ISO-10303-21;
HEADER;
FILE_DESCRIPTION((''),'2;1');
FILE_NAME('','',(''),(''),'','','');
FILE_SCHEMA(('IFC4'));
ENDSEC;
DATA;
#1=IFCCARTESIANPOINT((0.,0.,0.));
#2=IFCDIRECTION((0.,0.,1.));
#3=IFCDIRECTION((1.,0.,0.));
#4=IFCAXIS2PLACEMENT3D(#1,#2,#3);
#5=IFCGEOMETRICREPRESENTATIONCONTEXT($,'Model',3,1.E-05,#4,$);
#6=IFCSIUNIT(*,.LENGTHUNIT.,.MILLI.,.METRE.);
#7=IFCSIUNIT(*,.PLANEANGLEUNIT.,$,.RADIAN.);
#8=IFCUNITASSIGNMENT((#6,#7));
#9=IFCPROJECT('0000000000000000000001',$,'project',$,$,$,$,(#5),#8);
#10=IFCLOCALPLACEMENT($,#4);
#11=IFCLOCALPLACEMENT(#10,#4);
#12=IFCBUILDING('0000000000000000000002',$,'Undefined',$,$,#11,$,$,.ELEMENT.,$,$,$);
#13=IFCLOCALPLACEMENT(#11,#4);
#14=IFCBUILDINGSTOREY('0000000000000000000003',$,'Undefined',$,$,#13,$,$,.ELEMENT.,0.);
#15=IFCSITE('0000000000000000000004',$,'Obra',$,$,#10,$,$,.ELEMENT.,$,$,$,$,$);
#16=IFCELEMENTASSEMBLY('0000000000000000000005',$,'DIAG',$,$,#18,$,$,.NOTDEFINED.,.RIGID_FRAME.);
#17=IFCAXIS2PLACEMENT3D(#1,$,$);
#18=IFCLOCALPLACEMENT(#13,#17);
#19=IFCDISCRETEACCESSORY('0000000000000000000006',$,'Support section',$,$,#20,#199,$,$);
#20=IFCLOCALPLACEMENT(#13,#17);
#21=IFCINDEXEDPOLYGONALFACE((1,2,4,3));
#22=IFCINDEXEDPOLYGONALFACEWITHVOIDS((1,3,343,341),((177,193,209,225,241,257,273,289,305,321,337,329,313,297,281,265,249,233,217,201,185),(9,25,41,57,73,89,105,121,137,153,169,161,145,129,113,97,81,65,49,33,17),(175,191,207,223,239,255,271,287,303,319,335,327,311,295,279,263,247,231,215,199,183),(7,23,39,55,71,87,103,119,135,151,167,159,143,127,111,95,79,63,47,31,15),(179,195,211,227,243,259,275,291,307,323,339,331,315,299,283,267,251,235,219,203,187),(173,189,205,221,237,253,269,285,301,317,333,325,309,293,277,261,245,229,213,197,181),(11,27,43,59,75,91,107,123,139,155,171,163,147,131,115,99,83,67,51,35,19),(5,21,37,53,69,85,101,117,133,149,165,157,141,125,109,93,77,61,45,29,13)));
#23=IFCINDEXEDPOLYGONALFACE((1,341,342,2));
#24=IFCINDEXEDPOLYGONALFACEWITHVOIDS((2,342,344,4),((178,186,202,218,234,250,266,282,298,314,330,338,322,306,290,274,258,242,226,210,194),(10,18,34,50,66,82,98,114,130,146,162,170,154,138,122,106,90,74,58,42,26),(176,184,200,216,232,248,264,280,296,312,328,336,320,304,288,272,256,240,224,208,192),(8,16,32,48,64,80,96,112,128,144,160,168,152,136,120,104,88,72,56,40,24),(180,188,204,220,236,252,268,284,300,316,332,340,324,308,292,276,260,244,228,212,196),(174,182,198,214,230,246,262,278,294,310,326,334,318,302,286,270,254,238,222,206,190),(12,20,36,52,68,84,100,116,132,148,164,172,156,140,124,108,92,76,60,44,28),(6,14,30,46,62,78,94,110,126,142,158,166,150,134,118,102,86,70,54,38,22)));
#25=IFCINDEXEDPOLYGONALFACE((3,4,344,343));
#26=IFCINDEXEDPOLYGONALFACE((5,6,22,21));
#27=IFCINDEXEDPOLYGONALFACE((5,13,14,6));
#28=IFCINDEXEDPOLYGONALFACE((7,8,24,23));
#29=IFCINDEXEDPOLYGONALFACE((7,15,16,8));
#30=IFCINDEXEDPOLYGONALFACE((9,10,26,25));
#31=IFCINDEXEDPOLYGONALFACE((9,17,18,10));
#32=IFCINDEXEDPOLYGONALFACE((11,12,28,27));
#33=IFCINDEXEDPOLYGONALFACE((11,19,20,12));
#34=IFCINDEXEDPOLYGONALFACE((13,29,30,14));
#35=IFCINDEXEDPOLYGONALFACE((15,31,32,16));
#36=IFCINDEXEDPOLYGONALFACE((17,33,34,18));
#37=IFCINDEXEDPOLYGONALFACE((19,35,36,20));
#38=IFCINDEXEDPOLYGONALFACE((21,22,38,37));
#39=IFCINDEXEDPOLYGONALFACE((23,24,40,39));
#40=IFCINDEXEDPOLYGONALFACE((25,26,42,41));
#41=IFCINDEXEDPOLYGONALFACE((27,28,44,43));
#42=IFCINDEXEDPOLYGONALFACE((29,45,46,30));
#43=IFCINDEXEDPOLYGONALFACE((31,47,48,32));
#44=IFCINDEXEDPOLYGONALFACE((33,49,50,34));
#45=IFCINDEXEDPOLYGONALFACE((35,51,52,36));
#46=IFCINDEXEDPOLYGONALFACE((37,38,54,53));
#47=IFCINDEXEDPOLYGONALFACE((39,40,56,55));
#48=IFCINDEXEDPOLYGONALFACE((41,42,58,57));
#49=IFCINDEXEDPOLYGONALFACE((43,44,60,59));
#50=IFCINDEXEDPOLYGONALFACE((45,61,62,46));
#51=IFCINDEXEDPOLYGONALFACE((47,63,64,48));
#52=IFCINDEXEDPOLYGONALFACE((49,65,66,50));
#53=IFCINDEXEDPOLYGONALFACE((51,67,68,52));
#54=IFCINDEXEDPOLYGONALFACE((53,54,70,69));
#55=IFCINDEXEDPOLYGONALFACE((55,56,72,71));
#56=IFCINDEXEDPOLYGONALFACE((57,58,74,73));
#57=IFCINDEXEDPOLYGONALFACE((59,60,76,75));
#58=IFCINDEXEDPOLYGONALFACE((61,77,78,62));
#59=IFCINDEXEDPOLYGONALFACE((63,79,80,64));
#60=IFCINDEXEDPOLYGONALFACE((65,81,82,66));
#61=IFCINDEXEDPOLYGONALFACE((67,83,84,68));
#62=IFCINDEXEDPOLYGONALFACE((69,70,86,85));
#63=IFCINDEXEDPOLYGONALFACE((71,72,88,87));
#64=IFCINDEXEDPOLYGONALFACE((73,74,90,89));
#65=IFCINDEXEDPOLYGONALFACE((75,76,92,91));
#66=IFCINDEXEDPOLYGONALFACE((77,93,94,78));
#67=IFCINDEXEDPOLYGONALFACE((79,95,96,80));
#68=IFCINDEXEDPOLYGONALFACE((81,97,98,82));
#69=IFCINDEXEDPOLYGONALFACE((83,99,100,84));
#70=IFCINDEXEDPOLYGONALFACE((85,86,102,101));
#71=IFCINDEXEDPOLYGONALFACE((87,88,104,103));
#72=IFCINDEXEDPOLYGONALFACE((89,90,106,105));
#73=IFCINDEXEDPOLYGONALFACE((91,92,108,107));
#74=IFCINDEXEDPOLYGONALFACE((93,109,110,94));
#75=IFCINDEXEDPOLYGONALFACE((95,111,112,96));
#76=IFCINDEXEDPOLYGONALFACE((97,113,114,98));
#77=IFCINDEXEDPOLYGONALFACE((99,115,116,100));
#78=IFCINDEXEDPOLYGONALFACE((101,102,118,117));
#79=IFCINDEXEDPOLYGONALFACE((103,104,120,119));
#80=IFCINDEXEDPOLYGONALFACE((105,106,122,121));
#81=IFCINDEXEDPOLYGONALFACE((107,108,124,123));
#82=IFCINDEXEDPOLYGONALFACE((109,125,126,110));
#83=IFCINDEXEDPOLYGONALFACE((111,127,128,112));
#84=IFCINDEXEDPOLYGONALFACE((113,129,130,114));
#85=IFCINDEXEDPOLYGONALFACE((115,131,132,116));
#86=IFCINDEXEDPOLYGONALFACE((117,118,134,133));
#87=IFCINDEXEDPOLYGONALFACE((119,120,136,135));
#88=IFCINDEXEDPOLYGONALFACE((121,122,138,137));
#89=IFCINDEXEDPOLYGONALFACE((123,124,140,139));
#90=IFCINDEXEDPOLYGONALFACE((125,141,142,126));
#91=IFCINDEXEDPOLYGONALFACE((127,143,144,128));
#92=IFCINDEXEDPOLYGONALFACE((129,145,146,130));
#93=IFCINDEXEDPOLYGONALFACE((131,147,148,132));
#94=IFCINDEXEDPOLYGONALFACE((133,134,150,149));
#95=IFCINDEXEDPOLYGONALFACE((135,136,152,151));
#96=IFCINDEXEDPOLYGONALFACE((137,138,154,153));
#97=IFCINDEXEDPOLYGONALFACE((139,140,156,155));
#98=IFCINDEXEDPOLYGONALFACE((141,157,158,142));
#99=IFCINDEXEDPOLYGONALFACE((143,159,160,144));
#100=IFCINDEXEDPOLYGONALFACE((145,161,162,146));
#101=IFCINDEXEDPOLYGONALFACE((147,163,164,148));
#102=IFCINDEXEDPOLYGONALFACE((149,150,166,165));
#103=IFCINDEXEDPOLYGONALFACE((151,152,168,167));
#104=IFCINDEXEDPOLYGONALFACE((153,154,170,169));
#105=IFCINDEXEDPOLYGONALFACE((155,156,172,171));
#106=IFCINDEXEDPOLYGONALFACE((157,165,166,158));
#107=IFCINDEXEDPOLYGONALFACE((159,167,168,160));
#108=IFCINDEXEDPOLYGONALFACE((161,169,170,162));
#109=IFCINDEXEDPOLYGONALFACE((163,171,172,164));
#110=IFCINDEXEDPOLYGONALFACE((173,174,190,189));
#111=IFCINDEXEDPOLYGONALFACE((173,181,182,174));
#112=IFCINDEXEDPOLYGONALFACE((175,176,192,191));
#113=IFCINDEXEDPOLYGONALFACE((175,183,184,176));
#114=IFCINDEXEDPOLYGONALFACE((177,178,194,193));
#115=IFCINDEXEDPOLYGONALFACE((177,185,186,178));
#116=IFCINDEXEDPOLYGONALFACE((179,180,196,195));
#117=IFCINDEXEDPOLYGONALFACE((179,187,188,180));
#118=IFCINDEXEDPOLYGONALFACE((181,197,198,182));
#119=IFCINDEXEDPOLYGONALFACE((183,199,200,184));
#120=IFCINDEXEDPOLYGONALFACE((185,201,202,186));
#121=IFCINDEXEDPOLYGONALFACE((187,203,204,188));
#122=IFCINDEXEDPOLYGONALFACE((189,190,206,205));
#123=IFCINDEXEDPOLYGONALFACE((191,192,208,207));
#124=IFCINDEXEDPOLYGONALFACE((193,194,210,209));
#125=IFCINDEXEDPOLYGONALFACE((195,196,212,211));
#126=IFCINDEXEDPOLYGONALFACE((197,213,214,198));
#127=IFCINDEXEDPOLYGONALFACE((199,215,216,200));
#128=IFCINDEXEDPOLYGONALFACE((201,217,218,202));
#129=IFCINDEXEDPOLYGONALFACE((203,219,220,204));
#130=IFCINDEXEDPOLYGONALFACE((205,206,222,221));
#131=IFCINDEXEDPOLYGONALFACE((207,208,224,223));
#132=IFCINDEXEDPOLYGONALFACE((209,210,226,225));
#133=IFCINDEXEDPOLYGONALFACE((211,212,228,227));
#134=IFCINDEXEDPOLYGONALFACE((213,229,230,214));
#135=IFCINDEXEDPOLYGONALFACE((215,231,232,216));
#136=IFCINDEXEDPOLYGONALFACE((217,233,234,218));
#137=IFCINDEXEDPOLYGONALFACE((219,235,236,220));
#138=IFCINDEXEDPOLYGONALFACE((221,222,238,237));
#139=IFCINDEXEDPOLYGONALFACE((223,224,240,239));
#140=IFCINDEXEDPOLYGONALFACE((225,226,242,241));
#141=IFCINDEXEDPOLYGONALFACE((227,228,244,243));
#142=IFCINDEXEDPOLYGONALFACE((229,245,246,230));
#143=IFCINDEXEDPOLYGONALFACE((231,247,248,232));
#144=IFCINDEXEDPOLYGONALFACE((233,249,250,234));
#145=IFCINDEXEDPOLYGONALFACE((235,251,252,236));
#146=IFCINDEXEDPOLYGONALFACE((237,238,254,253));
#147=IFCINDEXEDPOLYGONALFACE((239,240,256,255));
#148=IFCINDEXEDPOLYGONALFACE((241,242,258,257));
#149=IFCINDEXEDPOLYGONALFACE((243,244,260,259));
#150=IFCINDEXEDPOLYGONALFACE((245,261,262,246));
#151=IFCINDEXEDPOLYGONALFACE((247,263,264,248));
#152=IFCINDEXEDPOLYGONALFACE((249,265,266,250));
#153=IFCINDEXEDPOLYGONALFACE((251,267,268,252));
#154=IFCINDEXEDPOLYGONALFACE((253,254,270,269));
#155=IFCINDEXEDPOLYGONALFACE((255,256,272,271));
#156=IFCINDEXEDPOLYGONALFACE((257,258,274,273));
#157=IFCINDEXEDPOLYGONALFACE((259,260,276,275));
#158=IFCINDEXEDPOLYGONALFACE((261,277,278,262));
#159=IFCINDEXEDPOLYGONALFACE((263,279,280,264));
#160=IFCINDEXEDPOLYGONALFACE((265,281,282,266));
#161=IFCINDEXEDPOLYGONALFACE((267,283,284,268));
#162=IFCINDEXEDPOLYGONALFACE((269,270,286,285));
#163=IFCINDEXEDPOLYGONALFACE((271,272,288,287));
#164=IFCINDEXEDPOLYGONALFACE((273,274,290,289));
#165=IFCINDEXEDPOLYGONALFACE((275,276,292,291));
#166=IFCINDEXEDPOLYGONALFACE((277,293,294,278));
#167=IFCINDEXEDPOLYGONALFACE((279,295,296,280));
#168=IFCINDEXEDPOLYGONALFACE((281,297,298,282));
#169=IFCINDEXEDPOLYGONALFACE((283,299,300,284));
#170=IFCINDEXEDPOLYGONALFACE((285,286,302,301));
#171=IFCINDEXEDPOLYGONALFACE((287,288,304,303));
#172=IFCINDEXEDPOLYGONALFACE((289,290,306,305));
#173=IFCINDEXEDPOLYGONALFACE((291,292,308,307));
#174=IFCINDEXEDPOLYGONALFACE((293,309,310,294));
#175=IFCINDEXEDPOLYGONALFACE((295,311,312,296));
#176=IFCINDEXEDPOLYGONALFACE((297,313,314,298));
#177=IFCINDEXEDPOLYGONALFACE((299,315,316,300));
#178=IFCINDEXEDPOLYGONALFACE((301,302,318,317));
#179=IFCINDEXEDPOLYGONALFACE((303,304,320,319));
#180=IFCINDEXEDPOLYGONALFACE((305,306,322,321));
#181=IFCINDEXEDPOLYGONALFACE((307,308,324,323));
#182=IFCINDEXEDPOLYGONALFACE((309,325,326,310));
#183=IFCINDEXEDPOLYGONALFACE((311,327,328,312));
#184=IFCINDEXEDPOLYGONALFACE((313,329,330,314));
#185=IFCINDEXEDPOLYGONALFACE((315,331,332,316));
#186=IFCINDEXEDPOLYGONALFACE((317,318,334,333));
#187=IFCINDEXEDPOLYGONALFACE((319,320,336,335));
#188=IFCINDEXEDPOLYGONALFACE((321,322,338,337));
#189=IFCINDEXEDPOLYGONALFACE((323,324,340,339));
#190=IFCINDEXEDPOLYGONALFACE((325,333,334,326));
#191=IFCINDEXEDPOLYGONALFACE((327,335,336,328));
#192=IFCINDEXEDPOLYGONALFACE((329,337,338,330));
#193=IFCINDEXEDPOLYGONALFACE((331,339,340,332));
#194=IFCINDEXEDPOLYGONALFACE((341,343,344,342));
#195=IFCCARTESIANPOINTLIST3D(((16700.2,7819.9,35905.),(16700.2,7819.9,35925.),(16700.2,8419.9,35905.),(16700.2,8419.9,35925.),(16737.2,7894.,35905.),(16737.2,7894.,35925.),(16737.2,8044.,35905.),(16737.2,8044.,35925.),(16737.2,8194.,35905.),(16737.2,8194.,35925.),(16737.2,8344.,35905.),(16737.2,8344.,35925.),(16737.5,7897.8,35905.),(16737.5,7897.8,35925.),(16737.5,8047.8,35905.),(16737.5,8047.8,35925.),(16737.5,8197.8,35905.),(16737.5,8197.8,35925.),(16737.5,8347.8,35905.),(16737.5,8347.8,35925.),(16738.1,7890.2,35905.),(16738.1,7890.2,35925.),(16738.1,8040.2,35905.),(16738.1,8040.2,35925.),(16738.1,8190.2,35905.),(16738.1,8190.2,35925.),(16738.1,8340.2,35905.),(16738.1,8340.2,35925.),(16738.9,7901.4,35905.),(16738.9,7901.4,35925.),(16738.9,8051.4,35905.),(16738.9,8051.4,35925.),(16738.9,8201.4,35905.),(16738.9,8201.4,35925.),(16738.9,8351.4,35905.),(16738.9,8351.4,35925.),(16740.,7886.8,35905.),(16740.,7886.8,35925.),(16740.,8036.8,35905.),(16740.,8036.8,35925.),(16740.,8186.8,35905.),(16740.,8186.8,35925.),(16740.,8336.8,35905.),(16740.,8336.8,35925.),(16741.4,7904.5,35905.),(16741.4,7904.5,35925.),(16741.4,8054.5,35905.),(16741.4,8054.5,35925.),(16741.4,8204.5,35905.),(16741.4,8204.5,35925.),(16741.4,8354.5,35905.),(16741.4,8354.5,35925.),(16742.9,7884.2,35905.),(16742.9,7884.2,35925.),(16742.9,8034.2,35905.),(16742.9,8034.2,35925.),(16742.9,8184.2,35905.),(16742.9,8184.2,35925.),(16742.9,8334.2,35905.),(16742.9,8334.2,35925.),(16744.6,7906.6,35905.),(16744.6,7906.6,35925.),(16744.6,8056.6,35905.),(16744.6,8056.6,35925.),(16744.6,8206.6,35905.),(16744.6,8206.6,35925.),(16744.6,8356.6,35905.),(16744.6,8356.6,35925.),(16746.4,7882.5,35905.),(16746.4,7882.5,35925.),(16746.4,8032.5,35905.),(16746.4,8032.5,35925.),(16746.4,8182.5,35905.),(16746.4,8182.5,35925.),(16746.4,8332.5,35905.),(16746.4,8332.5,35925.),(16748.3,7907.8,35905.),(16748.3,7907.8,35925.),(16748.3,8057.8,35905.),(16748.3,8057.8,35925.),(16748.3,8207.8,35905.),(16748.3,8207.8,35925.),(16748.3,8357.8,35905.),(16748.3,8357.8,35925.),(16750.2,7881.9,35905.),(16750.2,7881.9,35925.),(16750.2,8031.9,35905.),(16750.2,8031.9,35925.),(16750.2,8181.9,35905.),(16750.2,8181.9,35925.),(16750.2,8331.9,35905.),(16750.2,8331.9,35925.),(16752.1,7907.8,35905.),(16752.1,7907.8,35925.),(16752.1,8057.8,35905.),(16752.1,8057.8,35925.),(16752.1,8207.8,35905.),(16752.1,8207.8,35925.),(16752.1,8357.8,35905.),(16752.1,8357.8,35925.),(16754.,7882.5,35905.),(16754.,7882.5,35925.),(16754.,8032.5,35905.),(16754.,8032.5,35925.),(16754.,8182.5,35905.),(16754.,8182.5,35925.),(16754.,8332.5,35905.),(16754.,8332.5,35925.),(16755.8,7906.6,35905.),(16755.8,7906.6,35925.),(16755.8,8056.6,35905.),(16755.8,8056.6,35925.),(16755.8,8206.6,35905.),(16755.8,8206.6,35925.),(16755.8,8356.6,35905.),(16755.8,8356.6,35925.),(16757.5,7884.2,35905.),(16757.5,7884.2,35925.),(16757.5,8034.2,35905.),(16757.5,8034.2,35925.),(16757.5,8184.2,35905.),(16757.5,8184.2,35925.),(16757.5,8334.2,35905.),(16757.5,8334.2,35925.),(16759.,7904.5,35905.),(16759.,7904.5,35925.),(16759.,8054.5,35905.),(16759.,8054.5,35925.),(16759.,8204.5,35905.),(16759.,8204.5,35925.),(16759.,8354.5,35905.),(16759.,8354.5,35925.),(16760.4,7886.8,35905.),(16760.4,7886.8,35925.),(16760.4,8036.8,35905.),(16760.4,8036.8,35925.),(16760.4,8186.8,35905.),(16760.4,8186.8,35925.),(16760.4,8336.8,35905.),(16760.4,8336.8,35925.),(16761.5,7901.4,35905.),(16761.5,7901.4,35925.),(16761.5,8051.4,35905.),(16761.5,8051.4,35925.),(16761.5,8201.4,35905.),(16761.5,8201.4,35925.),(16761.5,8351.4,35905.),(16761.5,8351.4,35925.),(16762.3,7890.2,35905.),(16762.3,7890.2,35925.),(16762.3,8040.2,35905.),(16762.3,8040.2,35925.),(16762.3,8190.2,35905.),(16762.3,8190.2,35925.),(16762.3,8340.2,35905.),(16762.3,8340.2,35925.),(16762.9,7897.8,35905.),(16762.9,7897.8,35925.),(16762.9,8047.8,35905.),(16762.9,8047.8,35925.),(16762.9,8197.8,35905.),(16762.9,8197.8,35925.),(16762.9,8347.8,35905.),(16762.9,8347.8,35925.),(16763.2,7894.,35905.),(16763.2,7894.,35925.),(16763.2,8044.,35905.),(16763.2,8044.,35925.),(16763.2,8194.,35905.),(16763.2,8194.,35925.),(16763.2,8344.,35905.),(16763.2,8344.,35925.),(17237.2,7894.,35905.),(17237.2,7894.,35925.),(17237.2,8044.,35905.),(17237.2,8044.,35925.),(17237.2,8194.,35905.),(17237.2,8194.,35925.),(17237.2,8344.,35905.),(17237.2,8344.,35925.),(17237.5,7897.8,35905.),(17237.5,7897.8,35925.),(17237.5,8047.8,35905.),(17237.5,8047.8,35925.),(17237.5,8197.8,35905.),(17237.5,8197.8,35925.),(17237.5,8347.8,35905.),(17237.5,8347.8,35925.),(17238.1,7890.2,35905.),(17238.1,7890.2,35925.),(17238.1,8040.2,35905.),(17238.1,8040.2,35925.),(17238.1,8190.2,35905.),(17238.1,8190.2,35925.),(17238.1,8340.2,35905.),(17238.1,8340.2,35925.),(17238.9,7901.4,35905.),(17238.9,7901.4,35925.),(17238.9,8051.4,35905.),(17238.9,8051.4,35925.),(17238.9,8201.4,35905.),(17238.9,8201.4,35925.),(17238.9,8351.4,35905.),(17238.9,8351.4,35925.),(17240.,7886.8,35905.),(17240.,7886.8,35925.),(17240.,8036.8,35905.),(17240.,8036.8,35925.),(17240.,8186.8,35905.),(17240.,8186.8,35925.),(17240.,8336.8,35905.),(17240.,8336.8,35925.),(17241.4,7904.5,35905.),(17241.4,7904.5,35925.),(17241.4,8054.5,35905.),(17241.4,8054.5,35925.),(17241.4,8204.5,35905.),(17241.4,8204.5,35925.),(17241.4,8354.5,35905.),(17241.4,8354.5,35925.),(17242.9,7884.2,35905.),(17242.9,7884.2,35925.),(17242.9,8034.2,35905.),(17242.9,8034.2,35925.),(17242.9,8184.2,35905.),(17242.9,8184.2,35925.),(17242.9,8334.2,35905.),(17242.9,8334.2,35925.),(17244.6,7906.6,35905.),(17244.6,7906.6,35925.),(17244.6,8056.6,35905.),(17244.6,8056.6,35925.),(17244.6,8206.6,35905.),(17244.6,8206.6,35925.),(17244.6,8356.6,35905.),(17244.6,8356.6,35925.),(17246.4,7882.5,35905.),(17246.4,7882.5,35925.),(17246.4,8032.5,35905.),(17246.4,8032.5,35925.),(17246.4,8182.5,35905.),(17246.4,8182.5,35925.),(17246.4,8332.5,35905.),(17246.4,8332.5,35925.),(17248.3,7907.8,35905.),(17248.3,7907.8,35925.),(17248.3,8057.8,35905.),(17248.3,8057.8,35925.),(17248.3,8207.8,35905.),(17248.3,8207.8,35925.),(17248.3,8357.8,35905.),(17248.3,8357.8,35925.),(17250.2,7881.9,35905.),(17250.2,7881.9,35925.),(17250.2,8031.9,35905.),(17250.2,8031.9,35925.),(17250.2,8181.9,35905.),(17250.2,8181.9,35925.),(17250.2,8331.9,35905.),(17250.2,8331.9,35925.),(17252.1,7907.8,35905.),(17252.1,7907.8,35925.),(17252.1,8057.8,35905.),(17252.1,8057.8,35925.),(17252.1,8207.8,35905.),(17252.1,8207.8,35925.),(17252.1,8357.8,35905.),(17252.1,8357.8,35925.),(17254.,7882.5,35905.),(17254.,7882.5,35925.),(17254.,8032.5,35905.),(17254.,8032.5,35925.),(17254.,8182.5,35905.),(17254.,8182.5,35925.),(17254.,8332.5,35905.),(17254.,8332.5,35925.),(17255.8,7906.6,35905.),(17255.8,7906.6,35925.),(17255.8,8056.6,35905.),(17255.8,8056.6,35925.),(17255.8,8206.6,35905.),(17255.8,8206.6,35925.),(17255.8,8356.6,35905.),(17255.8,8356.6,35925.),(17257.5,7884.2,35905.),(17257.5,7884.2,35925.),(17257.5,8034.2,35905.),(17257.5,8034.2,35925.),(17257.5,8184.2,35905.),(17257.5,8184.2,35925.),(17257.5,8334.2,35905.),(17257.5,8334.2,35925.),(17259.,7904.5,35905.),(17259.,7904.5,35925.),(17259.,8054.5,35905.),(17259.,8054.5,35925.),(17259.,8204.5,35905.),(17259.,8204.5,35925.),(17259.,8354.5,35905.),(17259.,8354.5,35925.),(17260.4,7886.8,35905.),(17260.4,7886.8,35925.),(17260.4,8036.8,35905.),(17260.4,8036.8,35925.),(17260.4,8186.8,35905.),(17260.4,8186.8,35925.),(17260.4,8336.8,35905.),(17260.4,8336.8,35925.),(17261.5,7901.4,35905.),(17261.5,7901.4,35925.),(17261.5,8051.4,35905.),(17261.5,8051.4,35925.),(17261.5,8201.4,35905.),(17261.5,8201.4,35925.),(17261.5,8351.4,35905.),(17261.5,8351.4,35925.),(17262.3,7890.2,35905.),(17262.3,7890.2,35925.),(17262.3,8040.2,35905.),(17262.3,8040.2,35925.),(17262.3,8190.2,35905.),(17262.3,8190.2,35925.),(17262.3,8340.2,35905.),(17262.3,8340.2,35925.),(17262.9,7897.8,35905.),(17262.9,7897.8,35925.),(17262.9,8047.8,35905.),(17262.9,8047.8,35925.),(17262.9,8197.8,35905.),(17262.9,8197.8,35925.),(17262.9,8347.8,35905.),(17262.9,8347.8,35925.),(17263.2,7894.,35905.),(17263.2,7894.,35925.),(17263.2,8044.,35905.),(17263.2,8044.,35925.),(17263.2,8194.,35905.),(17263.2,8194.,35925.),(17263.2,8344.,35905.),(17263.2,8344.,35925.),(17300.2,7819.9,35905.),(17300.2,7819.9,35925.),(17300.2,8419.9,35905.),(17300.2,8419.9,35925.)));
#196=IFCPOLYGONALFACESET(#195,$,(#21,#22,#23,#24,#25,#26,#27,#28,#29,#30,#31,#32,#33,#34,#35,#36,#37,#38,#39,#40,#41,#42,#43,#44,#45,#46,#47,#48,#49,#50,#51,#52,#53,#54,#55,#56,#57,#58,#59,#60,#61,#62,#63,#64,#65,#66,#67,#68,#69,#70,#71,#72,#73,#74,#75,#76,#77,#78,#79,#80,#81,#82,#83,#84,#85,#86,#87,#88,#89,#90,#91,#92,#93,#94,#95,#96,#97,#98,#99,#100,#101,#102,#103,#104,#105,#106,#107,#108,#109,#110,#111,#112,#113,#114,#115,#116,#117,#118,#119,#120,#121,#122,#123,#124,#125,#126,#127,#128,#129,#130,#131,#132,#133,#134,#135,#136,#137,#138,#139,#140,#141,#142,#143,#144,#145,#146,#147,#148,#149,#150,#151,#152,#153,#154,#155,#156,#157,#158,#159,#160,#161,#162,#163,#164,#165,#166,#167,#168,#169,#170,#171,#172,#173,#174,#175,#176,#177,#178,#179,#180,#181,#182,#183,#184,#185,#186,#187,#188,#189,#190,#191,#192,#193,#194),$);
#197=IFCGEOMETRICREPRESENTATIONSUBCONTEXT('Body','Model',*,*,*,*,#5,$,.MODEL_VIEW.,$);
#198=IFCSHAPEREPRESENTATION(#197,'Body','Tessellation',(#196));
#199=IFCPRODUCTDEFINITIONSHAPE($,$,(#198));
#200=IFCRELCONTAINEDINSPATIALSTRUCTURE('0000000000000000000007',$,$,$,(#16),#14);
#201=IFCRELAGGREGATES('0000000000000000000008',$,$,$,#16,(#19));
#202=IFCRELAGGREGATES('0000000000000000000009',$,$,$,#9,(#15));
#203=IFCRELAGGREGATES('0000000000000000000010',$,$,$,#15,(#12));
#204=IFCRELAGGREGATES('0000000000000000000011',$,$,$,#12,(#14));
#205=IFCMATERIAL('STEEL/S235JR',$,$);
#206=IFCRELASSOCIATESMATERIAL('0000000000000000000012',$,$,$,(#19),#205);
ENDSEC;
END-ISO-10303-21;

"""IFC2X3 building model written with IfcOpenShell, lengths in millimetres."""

from ifc_helpers import new_model, si_unit, frame, origin_with_axes, origin_2d_with_axis, place, context, subcontext, project, spatial, rectangle, circle, extrude, source, transform, mapped, material, element, aggregate, save


model = new_model("IFC2X3")

# Units and contexts
model_context = context("Model", 3, precision=1e-05, world=origin_with_axes())
body_context = subcontext(model_context, "Body", "Model", "MODEL_VIEW")
ifc_project = project(units=[si_unit("LENGTHUNIT", "METRE", prefix="MILLI"), si_unit("PLANEANGLEUNIT", "RADIAN")], contexts=[model_context])

# Site, building, storey
site_placement = place(None, origin_with_axes())
site = spatial("IfcSite", under=ifc_project, at=site_placement, Name="Obra", CompositionType="ELEMENT")
building_placement = place(site_placement, origin_with_axes())
building = spatial("IfcBuilding", under=site, at=building_placement, Name="Undefined", CompositionType="ELEMENT")
storey_placement = place(building_placement, origin_with_axes())
storey = spatial("IfcBuildingStorey", under=building, at=storey_placement, Name="Undefined", CompositionType="ELEMENT", Elevation=0.0)

# Shared definitions
ifc_material_1 = material(Name="STEEL/S235JR")

# Element assembly, discrete accessory, opening
assembly_1_placement = place(storey_placement, origin_with_axes())
assembly_1 = element("IfcElementAssembly", 1, at=assembly_1_placement, inside=storey, Name="DIAG", AssemblyPlace="NOTDEFINED", PredefinedType="RIGID_FRAME")
discrete_accessory_1_placement = place(assembly_1_placement, frame((17000.2, 7819.9, 35915.0), z_axis=(1.0, 0.0, 0.0), x_axis=(0.0, 1.0, 0.0)))
discrete_accessory_1 = element("IfcDiscreteAccessory", 2, at=discrete_accessory_1_placement, material=ifc_material_1, Name="Support section", context=body_context, shape_type="SweptSolid", body=[
    extrude(rectangle(XDim=20.0, YDim=600.0, at=origin_2d_with_axis()), frame((600.0, 0.0, 0.0), z_axis=(-1.0, 0.0, 0.0), x_axis=(0.0, -1.0, 0.0)), (0.0, 0.0, 1.0), 600.0),
])
shared_shape_1 = source(origin_with_axes(), body_context, "Body", "SweptSolid", [
    extrude(circle(Radius=13.0, at=origin_2d_with_axis()), frame((0.0, -20.1, 0.0), z_axis=(0.0, 1.0, 0.0), x_axis=(1.0, 0.0, 0.0)), (0.0, 0.0, 1.0), 20.2),
])
opening_1_placement = place(assembly_1_placement, frame((17000.2, 8322.9, 35905.0), z_axis=(1.0, 0.0, 0.0), x_axis=(0.0, -1.0, 0.0)))
element("IfcOpeningElement", 3, at=opening_1_placement, cuts=discrete_accessory_1, ObjectType="Opening", context=body_context, shape_type="MappedRepresentation", body=[
    mapped(shared_shape_1, transform((-22.0, 0.0, -250.0))),
    mapped(shared_shape_1, transform((-22.0, 0.0, 250.0))),
    mapped(shared_shape_1, transform((128.0, 0.0, -250.0))),
    mapped(shared_shape_1, transform((128.0, 0.0, 250.0))),
    mapped(shared_shape_1, transform((278.0, 0.0, -250.0))),
    mapped(shared_shape_1, transform((278.0, 0.0, 250.0))),
    mapped(shared_shape_1, transform((428.0, 0.0, -250.0))),
    mapped(shared_shape_1, transform((428.0, 0.0, 250.0))),
])
aggregate(assembly_1, [discrete_accessory_1])

save(model, "model.ifc")
